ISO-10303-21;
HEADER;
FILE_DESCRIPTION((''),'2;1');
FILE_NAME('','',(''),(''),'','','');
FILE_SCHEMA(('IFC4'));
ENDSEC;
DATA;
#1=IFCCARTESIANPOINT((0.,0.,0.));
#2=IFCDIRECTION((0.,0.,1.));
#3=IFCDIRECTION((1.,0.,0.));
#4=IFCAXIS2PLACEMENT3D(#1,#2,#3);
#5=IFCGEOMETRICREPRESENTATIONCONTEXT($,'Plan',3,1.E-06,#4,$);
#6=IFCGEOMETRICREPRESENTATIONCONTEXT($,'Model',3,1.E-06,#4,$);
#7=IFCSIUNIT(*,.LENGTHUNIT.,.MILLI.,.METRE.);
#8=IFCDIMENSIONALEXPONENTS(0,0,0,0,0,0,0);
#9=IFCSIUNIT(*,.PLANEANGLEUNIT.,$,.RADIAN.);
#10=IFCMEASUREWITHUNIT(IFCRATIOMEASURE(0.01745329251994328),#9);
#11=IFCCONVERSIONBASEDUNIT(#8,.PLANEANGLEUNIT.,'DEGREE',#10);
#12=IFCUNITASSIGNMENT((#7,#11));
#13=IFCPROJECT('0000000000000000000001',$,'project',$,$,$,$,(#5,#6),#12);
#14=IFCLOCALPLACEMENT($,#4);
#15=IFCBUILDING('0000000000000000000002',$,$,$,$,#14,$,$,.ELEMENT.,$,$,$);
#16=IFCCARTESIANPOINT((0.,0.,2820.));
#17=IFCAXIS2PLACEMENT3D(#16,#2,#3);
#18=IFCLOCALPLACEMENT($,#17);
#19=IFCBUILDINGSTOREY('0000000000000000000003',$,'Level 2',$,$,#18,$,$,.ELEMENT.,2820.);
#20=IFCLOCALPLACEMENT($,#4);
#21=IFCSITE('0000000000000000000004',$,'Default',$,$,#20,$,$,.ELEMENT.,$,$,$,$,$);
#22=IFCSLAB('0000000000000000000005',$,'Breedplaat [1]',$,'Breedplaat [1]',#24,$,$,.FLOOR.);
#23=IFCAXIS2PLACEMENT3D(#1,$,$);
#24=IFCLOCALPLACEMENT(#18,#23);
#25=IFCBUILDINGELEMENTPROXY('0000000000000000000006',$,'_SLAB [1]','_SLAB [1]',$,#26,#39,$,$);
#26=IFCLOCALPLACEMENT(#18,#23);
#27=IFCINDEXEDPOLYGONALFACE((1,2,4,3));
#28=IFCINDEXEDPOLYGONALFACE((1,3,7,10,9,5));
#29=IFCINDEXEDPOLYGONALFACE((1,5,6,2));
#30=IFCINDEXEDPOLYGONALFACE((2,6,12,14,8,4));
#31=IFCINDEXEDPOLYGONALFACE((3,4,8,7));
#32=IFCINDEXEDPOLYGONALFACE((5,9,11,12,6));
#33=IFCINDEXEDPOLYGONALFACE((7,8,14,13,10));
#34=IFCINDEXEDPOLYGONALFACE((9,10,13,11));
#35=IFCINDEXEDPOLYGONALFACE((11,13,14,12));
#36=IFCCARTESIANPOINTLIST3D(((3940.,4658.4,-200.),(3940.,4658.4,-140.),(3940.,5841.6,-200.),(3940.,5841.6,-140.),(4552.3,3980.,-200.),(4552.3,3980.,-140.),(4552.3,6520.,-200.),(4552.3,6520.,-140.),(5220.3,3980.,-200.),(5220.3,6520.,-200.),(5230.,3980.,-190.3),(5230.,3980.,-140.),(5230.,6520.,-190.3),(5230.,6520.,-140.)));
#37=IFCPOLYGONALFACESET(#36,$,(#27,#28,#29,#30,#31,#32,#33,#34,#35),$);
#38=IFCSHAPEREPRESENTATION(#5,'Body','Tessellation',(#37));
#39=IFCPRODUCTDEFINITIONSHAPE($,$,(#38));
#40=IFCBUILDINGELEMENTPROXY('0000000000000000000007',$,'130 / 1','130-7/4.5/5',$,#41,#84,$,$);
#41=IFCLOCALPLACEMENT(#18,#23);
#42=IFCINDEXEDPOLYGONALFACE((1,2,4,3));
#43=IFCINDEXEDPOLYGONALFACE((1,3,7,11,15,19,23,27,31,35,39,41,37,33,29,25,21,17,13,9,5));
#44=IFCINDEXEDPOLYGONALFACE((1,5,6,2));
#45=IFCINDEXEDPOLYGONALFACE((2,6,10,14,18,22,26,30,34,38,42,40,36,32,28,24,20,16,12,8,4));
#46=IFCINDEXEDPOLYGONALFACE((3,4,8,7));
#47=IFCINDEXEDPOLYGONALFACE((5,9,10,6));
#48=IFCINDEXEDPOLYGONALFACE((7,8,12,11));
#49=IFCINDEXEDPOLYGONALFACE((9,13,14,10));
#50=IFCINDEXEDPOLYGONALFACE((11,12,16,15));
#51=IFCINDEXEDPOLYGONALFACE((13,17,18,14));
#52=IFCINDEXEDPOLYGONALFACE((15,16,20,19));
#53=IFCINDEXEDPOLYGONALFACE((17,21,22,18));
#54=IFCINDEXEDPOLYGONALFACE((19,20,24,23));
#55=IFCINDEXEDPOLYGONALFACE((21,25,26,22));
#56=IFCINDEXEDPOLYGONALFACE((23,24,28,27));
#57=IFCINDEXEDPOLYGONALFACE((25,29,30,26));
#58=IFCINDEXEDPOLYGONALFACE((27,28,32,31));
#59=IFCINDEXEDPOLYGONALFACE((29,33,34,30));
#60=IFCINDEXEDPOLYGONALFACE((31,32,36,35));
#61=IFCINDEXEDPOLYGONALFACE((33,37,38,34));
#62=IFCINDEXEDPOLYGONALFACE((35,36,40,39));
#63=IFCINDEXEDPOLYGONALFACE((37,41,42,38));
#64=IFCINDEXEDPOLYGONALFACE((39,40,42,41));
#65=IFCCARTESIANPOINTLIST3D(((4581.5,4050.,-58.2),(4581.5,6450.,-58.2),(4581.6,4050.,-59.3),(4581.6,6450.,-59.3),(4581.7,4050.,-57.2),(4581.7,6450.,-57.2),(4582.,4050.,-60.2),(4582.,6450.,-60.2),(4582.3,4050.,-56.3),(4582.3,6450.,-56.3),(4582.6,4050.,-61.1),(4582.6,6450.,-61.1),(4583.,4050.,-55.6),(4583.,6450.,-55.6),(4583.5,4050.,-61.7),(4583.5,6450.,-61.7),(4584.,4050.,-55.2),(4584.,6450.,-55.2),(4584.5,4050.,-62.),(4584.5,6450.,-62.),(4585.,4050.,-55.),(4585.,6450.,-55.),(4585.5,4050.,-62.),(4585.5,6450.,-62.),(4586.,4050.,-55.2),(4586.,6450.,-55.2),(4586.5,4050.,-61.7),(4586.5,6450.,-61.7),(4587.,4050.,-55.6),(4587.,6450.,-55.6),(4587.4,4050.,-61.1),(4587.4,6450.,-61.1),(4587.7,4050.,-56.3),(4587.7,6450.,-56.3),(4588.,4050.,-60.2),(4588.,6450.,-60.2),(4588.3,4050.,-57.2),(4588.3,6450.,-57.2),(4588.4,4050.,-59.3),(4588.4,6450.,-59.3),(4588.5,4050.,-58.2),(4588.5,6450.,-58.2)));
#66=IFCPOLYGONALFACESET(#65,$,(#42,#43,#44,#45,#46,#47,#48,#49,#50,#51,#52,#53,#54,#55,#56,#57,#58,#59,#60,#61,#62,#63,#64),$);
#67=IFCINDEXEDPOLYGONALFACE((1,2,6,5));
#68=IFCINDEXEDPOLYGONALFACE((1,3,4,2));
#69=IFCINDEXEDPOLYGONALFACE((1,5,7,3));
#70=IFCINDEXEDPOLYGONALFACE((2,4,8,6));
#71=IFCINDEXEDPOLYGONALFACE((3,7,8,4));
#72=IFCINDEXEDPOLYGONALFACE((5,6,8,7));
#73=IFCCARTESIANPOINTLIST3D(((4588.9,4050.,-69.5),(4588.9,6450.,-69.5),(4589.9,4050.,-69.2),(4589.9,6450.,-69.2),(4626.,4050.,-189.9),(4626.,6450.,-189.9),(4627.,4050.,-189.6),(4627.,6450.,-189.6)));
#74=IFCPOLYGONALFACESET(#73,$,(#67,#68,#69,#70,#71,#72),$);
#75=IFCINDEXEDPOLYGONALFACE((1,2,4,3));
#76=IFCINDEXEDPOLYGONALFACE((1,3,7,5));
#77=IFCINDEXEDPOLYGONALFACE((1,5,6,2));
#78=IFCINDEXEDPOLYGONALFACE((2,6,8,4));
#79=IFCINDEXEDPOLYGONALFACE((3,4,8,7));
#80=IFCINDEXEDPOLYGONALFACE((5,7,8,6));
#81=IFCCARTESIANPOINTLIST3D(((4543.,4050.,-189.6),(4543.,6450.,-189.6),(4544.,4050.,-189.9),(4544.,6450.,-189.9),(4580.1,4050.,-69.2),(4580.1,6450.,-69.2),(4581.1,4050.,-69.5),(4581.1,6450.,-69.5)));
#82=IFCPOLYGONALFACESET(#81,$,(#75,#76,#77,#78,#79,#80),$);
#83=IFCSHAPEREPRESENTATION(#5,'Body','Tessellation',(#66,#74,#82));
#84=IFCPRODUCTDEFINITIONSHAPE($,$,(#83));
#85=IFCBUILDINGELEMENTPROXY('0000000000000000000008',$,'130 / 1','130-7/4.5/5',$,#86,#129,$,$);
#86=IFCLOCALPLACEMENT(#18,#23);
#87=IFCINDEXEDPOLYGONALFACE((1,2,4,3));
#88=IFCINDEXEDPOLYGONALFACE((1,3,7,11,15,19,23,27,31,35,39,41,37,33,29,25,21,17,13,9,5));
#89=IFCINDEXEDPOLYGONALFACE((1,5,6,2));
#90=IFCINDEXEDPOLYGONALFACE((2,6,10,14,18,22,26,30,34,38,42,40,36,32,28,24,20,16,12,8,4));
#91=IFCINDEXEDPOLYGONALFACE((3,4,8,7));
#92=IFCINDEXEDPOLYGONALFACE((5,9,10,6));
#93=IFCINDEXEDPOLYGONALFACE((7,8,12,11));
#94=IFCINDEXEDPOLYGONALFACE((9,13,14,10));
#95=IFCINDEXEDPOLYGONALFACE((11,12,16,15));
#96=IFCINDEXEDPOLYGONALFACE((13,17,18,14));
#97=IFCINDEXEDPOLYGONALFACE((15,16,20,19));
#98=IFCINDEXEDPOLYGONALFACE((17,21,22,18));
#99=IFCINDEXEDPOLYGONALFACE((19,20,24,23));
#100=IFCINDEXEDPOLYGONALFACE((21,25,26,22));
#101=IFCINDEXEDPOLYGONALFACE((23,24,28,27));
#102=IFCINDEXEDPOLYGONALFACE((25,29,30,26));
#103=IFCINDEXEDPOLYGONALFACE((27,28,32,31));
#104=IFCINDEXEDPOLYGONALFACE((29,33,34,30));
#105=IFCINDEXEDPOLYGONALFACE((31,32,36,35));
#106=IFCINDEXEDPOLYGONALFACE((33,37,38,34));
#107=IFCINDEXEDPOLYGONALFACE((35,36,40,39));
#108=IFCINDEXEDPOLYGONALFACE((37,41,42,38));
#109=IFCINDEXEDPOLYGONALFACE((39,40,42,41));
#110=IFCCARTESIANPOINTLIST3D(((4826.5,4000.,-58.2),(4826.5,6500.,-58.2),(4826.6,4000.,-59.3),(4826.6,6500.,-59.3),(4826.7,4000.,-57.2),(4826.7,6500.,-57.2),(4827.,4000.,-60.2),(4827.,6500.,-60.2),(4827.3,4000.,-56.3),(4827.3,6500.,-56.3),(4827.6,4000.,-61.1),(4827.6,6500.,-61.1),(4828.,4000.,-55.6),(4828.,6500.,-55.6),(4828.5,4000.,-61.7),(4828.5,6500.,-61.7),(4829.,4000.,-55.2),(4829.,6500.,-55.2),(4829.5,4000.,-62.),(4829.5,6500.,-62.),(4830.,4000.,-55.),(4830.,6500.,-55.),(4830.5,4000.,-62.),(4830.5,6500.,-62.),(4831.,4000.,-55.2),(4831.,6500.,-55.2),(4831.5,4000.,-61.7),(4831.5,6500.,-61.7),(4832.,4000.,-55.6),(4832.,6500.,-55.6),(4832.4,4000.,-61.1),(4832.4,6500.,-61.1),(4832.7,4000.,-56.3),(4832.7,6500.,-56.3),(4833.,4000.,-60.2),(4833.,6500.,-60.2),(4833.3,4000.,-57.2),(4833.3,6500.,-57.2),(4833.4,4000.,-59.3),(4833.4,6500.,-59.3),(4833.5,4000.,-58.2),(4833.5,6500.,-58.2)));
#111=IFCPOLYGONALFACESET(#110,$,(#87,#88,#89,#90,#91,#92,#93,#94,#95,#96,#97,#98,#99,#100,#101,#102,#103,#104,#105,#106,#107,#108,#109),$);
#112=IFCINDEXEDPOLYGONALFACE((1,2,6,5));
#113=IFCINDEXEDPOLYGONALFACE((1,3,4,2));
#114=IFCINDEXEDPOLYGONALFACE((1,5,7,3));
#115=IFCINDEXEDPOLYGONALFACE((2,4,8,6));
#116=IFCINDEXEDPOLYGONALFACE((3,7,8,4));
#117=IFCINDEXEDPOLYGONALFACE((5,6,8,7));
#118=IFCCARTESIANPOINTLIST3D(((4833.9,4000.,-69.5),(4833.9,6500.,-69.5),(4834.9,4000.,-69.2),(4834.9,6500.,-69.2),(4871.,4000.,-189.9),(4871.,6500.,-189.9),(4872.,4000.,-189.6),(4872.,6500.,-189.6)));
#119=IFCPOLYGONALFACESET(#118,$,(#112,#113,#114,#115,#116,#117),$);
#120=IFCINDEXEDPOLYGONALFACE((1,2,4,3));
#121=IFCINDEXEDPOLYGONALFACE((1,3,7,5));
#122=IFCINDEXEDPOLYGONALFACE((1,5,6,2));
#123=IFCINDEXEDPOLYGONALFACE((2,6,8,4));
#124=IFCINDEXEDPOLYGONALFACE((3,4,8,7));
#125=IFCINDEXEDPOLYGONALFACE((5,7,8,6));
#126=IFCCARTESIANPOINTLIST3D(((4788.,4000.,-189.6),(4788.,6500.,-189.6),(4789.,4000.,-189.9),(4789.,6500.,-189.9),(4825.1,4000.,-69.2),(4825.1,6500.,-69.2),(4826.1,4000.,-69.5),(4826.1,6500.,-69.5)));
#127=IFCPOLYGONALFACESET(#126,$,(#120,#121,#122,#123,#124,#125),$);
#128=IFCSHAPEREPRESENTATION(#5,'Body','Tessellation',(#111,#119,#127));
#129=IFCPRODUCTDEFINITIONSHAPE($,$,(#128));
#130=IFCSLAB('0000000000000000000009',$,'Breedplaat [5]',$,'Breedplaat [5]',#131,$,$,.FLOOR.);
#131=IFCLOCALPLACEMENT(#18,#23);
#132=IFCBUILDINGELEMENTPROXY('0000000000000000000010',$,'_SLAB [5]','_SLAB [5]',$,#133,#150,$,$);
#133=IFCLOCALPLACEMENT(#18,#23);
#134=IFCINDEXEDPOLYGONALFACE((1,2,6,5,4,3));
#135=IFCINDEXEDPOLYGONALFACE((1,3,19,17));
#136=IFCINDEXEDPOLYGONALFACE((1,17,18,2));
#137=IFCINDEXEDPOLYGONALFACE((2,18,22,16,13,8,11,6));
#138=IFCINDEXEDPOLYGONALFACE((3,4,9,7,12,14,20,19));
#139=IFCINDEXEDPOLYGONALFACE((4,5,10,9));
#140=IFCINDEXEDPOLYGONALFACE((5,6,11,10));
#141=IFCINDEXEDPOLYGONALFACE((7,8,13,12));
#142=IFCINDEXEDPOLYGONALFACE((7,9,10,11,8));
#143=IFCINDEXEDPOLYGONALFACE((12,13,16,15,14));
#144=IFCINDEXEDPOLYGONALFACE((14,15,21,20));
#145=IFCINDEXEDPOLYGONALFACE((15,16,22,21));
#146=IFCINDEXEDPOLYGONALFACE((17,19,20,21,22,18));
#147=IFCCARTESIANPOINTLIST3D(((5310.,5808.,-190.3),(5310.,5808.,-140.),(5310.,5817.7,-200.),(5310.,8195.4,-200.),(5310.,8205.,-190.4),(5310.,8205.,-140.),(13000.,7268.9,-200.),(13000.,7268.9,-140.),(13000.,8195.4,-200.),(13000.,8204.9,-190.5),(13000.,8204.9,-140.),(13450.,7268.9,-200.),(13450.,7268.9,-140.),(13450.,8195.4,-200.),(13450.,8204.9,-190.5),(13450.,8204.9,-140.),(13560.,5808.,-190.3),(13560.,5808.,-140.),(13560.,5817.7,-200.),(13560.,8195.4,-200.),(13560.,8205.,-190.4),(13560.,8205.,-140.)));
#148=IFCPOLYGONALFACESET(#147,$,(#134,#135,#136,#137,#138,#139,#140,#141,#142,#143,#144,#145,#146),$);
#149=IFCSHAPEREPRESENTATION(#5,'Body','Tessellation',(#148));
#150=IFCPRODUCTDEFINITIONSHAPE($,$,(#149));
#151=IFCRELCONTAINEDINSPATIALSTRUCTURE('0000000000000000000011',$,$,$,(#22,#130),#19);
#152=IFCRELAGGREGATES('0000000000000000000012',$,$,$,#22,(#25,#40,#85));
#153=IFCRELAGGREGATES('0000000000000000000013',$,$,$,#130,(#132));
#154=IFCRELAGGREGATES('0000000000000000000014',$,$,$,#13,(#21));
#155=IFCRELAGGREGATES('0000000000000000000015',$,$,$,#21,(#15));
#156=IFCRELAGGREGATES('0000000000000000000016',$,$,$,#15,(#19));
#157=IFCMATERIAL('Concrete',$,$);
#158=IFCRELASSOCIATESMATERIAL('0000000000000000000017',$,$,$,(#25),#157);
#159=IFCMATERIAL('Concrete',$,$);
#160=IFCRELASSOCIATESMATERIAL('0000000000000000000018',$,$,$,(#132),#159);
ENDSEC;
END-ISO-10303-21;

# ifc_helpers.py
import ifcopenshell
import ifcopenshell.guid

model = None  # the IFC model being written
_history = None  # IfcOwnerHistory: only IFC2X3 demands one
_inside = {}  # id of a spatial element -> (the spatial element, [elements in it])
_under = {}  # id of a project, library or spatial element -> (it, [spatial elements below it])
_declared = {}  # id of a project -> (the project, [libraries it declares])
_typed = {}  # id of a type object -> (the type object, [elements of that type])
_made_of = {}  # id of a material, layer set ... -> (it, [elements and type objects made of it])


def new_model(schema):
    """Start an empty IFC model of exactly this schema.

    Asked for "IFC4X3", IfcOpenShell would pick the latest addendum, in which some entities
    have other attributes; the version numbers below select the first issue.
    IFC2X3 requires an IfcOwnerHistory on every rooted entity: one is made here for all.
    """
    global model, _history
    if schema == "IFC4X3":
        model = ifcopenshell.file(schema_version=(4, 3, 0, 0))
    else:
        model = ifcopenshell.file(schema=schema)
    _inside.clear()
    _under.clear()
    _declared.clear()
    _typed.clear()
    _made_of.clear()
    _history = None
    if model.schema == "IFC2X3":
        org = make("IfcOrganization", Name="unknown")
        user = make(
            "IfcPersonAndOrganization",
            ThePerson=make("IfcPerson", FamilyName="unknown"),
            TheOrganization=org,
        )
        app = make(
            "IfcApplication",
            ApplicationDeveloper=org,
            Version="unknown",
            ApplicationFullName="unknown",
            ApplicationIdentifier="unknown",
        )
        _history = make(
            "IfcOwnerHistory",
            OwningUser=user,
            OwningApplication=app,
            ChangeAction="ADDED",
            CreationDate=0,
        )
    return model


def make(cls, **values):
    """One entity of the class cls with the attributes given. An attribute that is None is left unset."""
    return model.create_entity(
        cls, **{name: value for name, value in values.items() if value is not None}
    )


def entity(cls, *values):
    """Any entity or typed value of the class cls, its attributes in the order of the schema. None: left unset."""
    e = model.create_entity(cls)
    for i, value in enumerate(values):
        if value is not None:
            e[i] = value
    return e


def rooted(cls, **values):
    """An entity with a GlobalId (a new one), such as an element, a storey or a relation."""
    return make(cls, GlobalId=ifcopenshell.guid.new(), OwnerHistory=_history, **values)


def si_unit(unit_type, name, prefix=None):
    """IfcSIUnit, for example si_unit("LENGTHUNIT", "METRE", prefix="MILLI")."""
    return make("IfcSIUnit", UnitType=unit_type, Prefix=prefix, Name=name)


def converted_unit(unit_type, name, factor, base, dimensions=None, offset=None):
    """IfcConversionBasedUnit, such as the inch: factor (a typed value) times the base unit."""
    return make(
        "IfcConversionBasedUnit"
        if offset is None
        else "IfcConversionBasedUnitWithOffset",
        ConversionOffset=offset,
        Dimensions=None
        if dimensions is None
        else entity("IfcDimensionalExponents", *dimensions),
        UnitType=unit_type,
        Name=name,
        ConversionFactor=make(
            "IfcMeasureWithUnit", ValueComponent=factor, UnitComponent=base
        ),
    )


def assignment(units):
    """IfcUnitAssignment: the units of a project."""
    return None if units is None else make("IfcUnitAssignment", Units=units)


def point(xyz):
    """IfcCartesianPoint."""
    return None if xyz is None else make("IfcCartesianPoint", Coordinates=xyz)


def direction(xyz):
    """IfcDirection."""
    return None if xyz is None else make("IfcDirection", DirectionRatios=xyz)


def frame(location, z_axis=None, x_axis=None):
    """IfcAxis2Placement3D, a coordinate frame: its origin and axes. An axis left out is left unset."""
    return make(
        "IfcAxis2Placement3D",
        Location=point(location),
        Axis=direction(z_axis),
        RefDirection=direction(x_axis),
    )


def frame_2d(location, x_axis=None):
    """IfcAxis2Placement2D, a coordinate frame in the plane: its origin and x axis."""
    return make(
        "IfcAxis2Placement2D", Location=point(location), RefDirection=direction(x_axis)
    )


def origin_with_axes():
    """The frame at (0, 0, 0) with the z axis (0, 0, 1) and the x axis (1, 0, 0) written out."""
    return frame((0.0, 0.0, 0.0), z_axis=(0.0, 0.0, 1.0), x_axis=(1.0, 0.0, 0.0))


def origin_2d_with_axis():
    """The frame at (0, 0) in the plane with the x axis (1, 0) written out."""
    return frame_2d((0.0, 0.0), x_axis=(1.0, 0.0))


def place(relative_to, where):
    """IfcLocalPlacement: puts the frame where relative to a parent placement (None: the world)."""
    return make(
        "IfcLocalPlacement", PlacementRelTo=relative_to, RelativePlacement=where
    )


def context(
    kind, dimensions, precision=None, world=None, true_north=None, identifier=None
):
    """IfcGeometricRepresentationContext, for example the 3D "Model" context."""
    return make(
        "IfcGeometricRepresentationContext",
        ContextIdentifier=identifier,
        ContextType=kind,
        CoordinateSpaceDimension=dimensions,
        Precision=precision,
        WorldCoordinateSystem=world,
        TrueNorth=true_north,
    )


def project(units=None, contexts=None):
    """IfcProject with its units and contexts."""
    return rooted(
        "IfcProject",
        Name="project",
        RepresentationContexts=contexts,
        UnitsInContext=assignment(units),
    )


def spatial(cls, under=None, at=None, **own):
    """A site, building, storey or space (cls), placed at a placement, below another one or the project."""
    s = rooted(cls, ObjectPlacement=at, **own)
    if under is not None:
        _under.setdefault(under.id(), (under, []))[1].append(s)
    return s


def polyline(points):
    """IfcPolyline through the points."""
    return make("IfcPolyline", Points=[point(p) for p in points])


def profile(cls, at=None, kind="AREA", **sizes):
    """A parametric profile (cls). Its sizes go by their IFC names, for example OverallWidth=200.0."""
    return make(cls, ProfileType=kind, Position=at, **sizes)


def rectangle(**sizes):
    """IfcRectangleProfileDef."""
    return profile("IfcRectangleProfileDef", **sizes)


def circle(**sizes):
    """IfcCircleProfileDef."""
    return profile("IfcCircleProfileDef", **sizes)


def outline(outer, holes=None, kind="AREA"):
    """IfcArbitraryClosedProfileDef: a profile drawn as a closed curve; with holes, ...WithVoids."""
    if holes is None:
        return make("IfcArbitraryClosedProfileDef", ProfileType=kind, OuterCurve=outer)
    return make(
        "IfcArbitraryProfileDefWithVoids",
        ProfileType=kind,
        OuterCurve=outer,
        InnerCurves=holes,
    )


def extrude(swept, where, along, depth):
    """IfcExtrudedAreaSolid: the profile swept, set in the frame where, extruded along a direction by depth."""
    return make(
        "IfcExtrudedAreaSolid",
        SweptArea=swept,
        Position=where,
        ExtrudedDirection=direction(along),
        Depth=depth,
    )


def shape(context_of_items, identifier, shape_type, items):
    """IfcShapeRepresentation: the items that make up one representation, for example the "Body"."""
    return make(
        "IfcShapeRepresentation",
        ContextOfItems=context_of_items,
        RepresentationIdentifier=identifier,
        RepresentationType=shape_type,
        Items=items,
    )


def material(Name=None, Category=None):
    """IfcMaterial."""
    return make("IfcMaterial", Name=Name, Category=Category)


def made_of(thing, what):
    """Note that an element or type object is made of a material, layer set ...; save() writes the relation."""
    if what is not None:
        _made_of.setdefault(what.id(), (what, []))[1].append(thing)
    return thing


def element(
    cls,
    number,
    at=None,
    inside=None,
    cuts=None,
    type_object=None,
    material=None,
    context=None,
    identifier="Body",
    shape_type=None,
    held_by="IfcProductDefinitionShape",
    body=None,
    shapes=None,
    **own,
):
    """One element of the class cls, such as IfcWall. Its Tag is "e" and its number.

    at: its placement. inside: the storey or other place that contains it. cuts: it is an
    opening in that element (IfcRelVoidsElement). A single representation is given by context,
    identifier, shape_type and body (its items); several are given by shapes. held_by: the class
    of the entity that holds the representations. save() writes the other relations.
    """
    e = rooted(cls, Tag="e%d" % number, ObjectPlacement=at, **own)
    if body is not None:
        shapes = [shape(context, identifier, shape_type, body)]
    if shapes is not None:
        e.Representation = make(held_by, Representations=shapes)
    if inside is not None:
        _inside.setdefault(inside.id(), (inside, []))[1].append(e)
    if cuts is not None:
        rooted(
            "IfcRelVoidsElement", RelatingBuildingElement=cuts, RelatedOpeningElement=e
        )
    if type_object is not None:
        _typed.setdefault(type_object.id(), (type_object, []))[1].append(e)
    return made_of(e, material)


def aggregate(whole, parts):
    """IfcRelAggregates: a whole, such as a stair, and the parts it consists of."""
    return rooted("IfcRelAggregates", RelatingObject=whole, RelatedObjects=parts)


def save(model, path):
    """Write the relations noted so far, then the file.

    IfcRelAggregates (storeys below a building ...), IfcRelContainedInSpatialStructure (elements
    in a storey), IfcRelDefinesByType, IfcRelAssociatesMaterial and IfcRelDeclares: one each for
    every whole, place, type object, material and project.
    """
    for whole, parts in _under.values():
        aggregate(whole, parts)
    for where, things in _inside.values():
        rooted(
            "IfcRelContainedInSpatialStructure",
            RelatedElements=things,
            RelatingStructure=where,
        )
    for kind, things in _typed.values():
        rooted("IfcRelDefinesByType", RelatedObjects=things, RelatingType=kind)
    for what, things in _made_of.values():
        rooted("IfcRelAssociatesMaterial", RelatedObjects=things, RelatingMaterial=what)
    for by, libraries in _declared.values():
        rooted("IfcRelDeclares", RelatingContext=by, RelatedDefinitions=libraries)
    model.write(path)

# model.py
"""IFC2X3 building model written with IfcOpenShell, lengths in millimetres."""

from ifc_helpers import new_model, entity, si_unit, converted_unit, frame, origin_with_axes, origin_2d_with_axis, place, context, project, spatial, polyline, rectangle, circle, outline, extrude, material, element, aggregate, save


model = new_model("IFC2X3")

# Units and contexts
plan_context = context("Plan", 3, precision=1e-06, world=origin_with_axes())
model_context = context("Model", 3, precision=1e-06, world=origin_with_axes())
ifc_project = project(units=[si_unit("LENGTHUNIT", "METRE", prefix="MILLI"), converted_unit("PLANEANGLEUNIT", "DEGREE", entity("IfcRatioMeasure", 0.01745329251994328), si_unit("PLANEANGLEUNIT", "RADIAN"), dimensions=[0, 0, 0, 0, 0, 0, 0])], contexts=[plan_context, model_context])

# Site, building, storey
site_placement = place(None, origin_with_axes())
site = spatial("IfcSite", under=ifc_project, at=site_placement, Name="Default", CompositionType="ELEMENT")
building_placement = place(None, origin_with_axes())
building = spatial("IfcBuilding", under=site, at=building_placement, CompositionType="ELEMENT")
storey_placement = place(None, frame((0.0, 0.0, 2820.0), z_axis=(0.0, 0.0, 1.0), x_axis=(1.0, 0.0, 0.0)))
storey = spatial("IfcBuildingStorey", under=building, at=storey_placement, Name="Level 2", CompositionType="ELEMENT", Elevation=2820.0)

# Slab, building element proxies, opening
slab_1_placement = place(None, frame((5230.0, 3980.0, 2620.0), z_axis=(0.0, 0.0, 1.0), x_axis=(0.0, 1.0, 0.0)))
slab_1 = element("IfcSlab", 1, at=slab_1_placement, inside=storey, Name="Breedplaat [1]", ObjectType="Breedplaat [1]", PredefinedType="FLOOR")
ifc_material_1 = material(Name="Concrete")
proxy_1_placement = place(slab_1_placement, origin_with_axes())
proxy_1 = element("IfcBuildingElementProxy", 2, at=proxy_1_placement, material=ifc_material_1, Name="_SLAB [1]", Description="_SLAB [1]", context=plan_context, shape_type="SweptSolid", body=[
    extrude(outline(polyline([(2540.0, 0.0), (2540.0, 677.8), (1861.6, 1290.0), (678.4, 1290.0), (0.0, 677.8), (0.0, 0.0), (2540.0, 0.0)])), origin_with_axes(), (0.0, 0.0, 1.0), 60.0),
])
opening_1_placement = place(None, frame((5230.0, 3980.0, 2620.0), z_axis=(0.0, 0.0, 1.0), x_axis=(0.0, 1.0, 0.0)))
element("IfcOpeningElement", 3, at=opening_1_placement, cuts=proxy_1, ObjectType="Opening", context=plan_context, shape_type="SweptSolid", body=[
    extrude(outline(polyline([(-0.1, -0.1), (-0.1, 10.0), (10.0, -0.1), (-0.1, -0.1)])), frame((-1.2, -0.1, -0.1), z_axis=(1.0, 0.0, 0.0), x_axis=(0.0, 1.0, 0.0)), (0.0, 0.0, 1.0), 2542.2),
])
proxy_2_placement = place(slab_1_placement, frame((70.0, 645.0, 15.0), z_axis=(0.0, 0.0, 1.0), x_axis=(1.0, 0.0, 0.0)))
proxy_2 = element("IfcBuildingElementProxy", 4, at=proxy_2_placement, Name="130 / 1", Description="130-7/4.5/5", context=plan_context, shape_type="SweptSolid", body=[
    extrude(circle(Radius=3.5, at=origin_2d_with_axis()), frame((0.0, 0.0, 126.5), z_axis=(1.0, 0.0, 0.0), x_axis=(0.0, 0.0, 1.0)), (0.0, 0.0, 1.0), 2400.0),
    extrude(rectangle(XDim=126.0, YDim=1.0, at=origin_2d_with_axis()), frame((0.0, -22.9, 55.4), z_axis=(1.0, 0.0, 0.0), x_axis=(0.0, 0.294086, 0.955779)), (0.0, 0.0, 1.0), 2400.0),
    extrude(rectangle(XDim=126.0, YDim=1.0, at=origin_2d_with_axis()), frame((0.0, 22.9, 55.4), z_axis=(1.0, 0.0, 0.0), x_axis=(0.0, -0.294086, 0.955779)), (0.0, 0.0, 1.0), 2400.0),
])
proxy_3_placement = place(slab_1_placement, frame((20.0, 400.0, 15.0), z_axis=(0.0, 0.0, 1.0), x_axis=(1.0, 0.0, 0.0)))
proxy_3 = element("IfcBuildingElementProxy", 5, at=proxy_3_placement, Name="130 / 1", Description="130-7/4.5/5", context=plan_context, shape_type="SweptSolid", body=[
    extrude(circle(Radius=3.5, at=origin_2d_with_axis()), frame((0.0, 0.0, 126.5), z_axis=(1.0, 0.0, 0.0), x_axis=(0.0, 0.0, 1.0)), (0.0, 0.0, 1.0), 2500.0),
    extrude(rectangle(XDim=126.0, YDim=1.0, at=origin_2d_with_axis()), frame((0.0, -22.9, 55.4), z_axis=(1.0, 0.0, 0.0), x_axis=(0.0, 0.294086, 0.955779)), (0.0, 0.0, 1.0), 2500.0),
    extrude(rectangle(XDim=126.0, YDim=1.0, at=origin_2d_with_axis()), frame((0.0, 22.9, 55.4), z_axis=(1.0, 0.0, 0.0), x_axis=(0.0, -0.294086, 0.955779)), (0.0, 0.0, 1.0), 2500.0),
])
aggregate(slab_1, [proxy_1, proxy_2, proxy_3])

# Slab, building element proxy, openings
slab_2_placement = place(None, frame((5310.0, 5808.0, 2620.0), z_axis=(0.0, 0.0, 1.0), x_axis=(1.0, 0.0, 0.0)))
slab_2 = element("IfcSlab", 6, at=slab_2_placement, inside=storey, Name="Breedplaat [5]", ObjectType="Breedplaat [5]", PredefinedType="FLOOR")
ifc_material_2 = material(Name="Concrete")
proxy_4_placement = place(slab_2_placement, origin_with_axes())
proxy_4 = element("IfcBuildingElementProxy", 7, at=proxy_4_placement, material=ifc_material_2, Name="_SLAB [5]", Description="_SLAB [5]", context=plan_context, shape_type="SweptSolid", body=[
    extrude(outline(polyline([(0.0, 0.0), (8250.0, 0.0), (8250.0, 2397.0), (0.0, 2397.0), (0.0, 0.0)])), origin_with_axes(), (0.0, 0.0, 1.0), 60.0),
])
opening_2_placement = place(slab_2_placement, frame((7690.0, 1460.9, 0.0), z_axis=(0.0, 0.0, 1.0), x_axis=(1.0, 0.0, 0.0)))
element("IfcOpeningElement", 8, at=opening_2_placement, cuts=proxy_4, ObjectType="Opening", context=plan_context, shape_type="SolidModel", body=[
    extrude(rectangle(XDim=450.0, YDim=936.0, at=origin_2d_with_axis()), frame((225.0, 468.0, 0.0), z_axis=(0.0, 0.0, 1.0), x_axis=(1.0, 0.0, 0.0)), (0.0, 0.0, 1.0), 60.0),
])
opening_3_placement = place(None, frame((5310.0, 5808.0, 2620.0), z_axis=(0.0, 0.0, 1.0), x_axis=(1.0, 0.0, 0.0)))
element("IfcOpeningElement", 9, at=opening_3_placement, cuts=proxy_4, ObjectType="Opening", context=plan_context, shape_type="SweptSolid", body=[
    extrude(outline(polyline([(-0.1, -0.1), (-0.1, 10.0), (10.0, -0.1), (-0.1, -0.1)])), frame((-1.2, -0.1, -0.1), z_axis=(1.0, 0.0, 0.0), x_axis=(0.0, 1.0, 0.0)), (0.0, 0.0, 1.0), 8252.2),
])
opening_4_placement = place(None, frame((5310.0, 5808.0, 2620.0), z_axis=(0.0, 0.0, 1.0), x_axis=(1.0, 0.0, 0.0)))
element("IfcOpeningElement", 10, at=opening_4_placement, cuts=proxy_4, ObjectType="Opening", context=plan_context, shape_type="SweptSolid", body=[
    extrude(outline(polyline([(-0.1, -0.1), (-0.1, 10.0), (10.0, -0.1), (-0.1, -0.1)])), frame((8251.2, 2397.2, -0.1), z_axis=(-1.0, 0.0, 0.0), x_axis=(0.0, -1.0, 0.0)), (0.0, 0.0, 1.0), 8252.2),
])
aggregate(slab_2, [proxy_4])

save(model, "model.ifc")
